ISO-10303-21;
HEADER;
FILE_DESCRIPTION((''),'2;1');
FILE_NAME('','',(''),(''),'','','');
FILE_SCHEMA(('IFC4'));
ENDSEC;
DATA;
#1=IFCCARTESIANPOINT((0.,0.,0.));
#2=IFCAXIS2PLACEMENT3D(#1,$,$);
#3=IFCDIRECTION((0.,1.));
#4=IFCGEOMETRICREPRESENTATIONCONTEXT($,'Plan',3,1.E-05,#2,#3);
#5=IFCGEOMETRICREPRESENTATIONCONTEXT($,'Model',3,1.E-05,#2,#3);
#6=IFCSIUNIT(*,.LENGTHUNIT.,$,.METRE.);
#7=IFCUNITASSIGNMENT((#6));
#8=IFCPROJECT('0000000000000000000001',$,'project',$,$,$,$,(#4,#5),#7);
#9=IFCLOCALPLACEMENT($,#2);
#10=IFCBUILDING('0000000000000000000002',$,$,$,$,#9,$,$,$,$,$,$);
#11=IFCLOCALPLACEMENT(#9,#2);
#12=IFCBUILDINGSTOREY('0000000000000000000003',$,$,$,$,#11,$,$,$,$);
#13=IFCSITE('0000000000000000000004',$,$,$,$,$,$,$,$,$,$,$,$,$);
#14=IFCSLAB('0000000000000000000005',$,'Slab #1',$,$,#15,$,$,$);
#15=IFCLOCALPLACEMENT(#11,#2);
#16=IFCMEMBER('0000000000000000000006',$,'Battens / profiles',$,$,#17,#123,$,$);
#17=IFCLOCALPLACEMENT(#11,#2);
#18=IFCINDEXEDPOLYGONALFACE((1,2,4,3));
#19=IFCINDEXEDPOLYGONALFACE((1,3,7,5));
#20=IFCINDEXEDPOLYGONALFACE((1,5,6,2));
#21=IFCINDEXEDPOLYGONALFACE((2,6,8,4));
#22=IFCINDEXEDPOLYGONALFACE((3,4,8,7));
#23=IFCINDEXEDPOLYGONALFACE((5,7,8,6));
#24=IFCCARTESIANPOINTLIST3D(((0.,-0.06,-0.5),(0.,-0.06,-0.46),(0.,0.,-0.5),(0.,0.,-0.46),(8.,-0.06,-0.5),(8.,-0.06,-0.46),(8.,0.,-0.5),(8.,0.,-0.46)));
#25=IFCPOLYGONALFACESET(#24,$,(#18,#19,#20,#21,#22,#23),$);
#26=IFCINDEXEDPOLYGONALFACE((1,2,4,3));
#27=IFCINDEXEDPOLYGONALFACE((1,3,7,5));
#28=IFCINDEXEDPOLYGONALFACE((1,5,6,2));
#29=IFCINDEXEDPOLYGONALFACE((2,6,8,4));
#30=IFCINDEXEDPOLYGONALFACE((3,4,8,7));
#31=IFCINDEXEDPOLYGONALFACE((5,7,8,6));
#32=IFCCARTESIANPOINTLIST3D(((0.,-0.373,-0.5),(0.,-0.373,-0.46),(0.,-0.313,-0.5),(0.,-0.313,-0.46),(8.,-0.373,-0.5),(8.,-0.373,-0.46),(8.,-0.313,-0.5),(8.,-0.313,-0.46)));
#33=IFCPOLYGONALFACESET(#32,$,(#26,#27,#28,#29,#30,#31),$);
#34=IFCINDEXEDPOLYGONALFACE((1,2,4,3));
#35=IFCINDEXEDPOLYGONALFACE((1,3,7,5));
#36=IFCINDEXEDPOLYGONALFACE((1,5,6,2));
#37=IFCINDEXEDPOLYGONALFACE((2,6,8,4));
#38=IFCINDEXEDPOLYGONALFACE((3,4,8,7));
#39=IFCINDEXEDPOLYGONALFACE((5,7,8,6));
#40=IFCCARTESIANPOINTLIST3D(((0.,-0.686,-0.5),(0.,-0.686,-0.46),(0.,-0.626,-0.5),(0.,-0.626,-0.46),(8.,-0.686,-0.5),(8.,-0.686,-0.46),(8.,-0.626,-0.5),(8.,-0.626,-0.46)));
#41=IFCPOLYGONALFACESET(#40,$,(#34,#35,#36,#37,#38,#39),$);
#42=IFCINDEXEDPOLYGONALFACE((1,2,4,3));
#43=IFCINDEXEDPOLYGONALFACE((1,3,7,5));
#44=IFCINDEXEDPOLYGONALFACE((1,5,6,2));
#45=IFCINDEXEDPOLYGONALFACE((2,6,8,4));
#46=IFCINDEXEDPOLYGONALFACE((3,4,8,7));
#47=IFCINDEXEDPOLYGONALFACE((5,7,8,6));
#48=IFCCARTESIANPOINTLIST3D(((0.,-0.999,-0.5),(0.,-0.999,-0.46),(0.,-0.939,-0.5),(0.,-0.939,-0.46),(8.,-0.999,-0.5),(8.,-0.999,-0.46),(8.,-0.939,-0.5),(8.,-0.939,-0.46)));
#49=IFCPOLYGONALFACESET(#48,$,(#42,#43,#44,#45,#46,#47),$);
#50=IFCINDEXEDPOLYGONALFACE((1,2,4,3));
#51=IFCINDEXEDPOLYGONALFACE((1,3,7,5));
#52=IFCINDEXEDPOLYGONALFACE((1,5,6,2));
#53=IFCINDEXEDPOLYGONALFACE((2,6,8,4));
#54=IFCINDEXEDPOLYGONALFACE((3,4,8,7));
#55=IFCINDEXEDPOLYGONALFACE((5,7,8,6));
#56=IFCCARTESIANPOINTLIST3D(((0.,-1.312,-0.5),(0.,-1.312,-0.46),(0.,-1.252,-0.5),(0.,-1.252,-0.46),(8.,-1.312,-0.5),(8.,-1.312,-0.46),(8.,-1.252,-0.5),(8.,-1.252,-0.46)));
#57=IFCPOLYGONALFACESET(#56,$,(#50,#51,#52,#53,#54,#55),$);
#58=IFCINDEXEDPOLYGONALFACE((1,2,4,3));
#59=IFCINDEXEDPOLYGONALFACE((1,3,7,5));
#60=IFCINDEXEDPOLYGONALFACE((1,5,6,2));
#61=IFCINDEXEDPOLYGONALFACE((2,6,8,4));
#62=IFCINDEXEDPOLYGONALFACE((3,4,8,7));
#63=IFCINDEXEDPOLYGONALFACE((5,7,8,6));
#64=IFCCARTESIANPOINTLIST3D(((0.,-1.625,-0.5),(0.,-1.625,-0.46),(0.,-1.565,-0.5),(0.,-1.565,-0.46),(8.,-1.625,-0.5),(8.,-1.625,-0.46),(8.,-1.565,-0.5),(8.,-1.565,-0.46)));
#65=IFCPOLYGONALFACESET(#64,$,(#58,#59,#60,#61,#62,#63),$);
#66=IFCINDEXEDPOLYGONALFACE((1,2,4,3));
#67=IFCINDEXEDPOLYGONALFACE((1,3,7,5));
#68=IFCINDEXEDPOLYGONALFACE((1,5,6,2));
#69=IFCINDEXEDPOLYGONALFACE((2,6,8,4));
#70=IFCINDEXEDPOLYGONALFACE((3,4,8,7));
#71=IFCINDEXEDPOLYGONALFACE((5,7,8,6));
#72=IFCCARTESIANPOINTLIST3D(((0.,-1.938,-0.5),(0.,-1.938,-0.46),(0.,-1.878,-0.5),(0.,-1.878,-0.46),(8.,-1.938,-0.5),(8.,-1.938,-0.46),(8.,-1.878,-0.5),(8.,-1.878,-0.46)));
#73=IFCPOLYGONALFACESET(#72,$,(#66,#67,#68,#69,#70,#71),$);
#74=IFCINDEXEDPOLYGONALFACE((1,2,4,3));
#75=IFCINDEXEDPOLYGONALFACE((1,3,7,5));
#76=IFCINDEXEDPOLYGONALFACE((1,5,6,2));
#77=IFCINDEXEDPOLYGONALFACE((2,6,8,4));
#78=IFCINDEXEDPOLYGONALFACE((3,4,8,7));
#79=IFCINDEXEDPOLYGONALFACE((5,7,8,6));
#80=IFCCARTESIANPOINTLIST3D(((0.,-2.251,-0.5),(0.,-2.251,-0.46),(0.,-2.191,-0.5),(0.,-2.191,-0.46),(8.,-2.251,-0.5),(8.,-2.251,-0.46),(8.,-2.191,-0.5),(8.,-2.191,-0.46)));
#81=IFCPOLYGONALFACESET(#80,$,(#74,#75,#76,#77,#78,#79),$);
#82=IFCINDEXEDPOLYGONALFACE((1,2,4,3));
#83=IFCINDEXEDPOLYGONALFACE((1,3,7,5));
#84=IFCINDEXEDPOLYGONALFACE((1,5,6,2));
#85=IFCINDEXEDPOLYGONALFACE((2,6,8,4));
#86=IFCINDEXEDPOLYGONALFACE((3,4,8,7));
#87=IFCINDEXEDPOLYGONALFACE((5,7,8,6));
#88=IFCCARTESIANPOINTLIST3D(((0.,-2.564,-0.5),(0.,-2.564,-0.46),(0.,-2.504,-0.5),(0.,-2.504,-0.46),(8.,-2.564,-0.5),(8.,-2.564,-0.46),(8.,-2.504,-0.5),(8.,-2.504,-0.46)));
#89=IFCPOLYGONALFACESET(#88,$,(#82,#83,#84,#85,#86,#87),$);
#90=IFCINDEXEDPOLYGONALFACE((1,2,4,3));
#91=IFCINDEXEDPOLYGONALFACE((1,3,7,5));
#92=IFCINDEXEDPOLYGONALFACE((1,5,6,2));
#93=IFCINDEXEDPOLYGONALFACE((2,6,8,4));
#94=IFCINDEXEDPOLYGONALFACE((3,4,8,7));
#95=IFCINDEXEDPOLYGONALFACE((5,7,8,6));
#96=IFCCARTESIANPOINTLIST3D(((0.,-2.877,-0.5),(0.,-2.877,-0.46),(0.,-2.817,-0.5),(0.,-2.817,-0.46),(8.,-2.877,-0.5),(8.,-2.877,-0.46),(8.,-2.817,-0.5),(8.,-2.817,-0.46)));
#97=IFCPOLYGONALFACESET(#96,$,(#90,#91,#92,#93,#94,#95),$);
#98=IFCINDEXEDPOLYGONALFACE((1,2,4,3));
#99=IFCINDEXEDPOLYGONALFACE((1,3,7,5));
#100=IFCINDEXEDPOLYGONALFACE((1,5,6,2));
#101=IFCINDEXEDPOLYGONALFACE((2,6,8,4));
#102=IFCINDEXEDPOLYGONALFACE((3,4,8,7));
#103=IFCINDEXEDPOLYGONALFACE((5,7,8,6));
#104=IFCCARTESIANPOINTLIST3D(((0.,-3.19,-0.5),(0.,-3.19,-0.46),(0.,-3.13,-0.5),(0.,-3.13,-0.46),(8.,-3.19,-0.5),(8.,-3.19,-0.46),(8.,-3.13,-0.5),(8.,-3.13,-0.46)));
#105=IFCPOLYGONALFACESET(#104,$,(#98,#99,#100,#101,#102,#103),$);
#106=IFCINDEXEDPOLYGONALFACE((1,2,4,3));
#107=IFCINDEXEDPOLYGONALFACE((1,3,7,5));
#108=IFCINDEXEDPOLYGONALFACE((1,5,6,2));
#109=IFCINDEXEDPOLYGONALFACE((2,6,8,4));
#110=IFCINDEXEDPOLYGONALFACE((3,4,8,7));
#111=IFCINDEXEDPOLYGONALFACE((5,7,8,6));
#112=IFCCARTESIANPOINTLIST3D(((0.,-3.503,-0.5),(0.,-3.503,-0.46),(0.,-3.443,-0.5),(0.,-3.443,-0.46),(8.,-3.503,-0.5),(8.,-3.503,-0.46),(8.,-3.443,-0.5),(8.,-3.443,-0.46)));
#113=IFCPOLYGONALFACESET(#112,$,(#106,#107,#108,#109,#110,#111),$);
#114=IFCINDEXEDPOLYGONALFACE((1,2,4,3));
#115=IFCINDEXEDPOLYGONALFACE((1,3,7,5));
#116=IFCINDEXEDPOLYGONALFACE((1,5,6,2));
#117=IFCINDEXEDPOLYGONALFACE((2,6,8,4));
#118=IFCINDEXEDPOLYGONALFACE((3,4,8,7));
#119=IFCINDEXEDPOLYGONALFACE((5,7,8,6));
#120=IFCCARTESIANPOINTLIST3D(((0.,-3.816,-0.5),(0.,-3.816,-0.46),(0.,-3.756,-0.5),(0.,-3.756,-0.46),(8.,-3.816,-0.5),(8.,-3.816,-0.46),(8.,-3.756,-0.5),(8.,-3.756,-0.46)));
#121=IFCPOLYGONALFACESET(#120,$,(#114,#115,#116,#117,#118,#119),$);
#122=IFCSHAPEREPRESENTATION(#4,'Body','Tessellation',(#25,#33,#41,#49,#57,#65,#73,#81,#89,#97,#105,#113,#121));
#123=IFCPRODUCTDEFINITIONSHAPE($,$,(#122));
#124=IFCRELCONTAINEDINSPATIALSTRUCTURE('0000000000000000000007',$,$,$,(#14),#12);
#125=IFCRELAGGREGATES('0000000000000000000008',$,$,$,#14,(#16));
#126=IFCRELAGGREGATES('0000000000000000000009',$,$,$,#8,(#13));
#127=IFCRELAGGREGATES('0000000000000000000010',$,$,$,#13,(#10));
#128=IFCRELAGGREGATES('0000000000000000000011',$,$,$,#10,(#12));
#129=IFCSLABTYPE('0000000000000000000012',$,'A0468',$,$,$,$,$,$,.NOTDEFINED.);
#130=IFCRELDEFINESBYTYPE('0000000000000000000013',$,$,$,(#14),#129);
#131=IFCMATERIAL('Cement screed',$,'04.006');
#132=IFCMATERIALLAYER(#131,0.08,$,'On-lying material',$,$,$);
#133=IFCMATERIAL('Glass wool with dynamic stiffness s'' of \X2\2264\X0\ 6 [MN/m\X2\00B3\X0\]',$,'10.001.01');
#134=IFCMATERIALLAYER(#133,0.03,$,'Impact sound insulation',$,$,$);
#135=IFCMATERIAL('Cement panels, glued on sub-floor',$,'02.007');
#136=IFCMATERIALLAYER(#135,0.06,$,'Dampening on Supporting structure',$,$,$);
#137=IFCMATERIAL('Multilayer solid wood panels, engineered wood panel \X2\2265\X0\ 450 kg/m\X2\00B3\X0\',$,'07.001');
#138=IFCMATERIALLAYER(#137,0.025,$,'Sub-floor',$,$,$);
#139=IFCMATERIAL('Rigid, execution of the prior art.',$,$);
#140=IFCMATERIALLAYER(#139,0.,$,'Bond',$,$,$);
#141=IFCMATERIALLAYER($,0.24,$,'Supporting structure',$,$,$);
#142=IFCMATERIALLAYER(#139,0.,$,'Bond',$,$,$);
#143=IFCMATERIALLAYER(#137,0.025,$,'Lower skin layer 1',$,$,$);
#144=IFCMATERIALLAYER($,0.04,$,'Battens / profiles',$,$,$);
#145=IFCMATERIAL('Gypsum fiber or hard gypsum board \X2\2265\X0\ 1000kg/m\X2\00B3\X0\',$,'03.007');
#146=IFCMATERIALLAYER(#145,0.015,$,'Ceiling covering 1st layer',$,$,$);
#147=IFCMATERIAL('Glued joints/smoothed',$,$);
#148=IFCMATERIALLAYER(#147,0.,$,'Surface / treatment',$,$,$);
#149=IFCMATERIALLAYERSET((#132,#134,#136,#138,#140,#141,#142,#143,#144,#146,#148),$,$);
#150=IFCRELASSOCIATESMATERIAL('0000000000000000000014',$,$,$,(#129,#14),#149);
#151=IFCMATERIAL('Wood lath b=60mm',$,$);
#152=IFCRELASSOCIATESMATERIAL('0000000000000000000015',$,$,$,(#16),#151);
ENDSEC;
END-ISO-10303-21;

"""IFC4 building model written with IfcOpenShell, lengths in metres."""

from ifc_helpers import new_model, si_unit, direction, frame, frame_2d, origin, place, context, project, spatial, rectangle, extrude, material, layer, layer_set, type_object, element, aggregate, save


model = new_model("IFC4")

# Units and contexts
plan_context = context("Plan", 3, precision=1e-05, world=origin(), true_north=direction((0.0, 1.0)))
model_context = context("Model", 3, precision=1e-05, world=origin(), true_north=direction((0.0, 1.0)))
ifc_project = project(units=[si_unit("LENGTHUNIT", "METRE")], contexts=[plan_context, model_context])

# Site, building, storey
site = spatial("IfcSite", under=ifc_project)
building_placement = place(None, origin())
building = spatial("IfcBuilding", under=site, at=building_placement)
storey_placement = place(building_placement, origin())
storey = spatial("IfcBuildingStorey", under=building, at=storey_placement)

# Slab, member
ifc_material_1 = material(Name="Cement screed", Category="04.006")
ifc_layer_1 = layer(ifc_material_1, 0.08, Name="On-lying material")
ifc_material_2 = material(Name="Glass wool with dynamic stiffness s' of ≤ 6 [MN/m³]", Category="10.001.01")
ifc_layer_2 = layer(ifc_material_2, 0.03, Name="Impact sound insulation")
ifc_material_3 = material(Name="Cement panels, glued on sub-floor", Category="02.007")
ifc_layer_3 = layer(ifc_material_3, 0.06, Name="Dampening on Supporting structure")
ifc_material_4 = material(Name="Multilayer solid wood panels, engineered wood panel ≥ 450 kg/m³", Category="07.001")
ifc_layer_4 = layer(ifc_material_4, 0.025, Name="Sub-floor")
ifc_material_5 = material(Name="Rigid, execution of the prior art.")
ifc_layer_5 = layer(ifc_material_5, 0.0, Name="Bond")
ifc_layer_6 = layer(None, 0.24, Name="Supporting structure")
ifc_layer_7 = layer(ifc_material_5, 0.0, Name="Bond")
ifc_layer_8 = layer(ifc_material_4, 0.025, Name="Lower skin layer 1")
ifc_layer_9 = layer(None, 0.04, Name="Battens / profiles")
ifc_material_6 = material(Name="Gypsum fiber or hard gypsum board ≥ 1000kg/m³", Category="03.007")
ifc_layer_10 = layer(ifc_material_6, 0.015, Name="Ceiling covering 1st layer")
ifc_material_7 = material(Name="Glued joints/smoothed")
ifc_layer_11 = layer(ifc_material_7, 0.0, Name="Surface / treatment")
ifc_layer_set = layer_set([ifc_layer_1, ifc_layer_2, ifc_layer_3, ifc_layer_4, ifc_layer_5, ifc_layer_6, ifc_layer_7, ifc_layer_8, ifc_layer_9, ifc_layer_10, ifc_layer_11])
slab_type = type_object("IfcSlabType", Name="A0468", PredefinedType="NOTDEFINED", material=ifc_layer_set)
slab_placement = place(None, frame((0.0, 0.0, 0.0), z_axis=(0.0, 0.0, -1.0), x_axis=(1.0, 0.0, 0.0)))
slab = element("IfcSlab", 1, at=slab_placement, inside=storey, type_object=slab_type, material=ifc_layer_set, Name="Slab #1")
ifc_material_8 = material(Name="Wood lath b=60mm")
member_1_placement = place(slab_placement, origin())
member_1 = element("IfcMember", 2, at=member_1_placement, material=ifc_material_8, Name="Battens / profiles", context=plan_context, shape_type="SweptSolid", body=[
    extrude(rectangle(XDim=0.06, YDim=0.04, at=frame_2d((0.03, 0.02), x_axis=(1.0, 0.0))), frame((0.0, 0.0, 0.46), z_axis=(1.0, 0.0, 0.0), x_axis=(0.0, 1.0, 0.0)), (0.0, 0.0, 1.0), 8.0),
    extrude(rectangle(XDim=0.06, YDim=0.04, at=frame_2d((0.03, 0.02), x_axis=(1.0, 0.0))), frame((0.0, 0.313, 0.46), z_axis=(1.0, 0.0, 0.0), x_axis=(0.0, 1.0, 0.0)), (0.0, 0.0, 1.0), 8.0),
    extrude(rectangle(XDim=0.06, YDim=0.04, at=frame_2d((0.03, 0.02), x_axis=(1.0, 0.0))), frame((0.0, 0.626, 0.46), z_axis=(1.0, 0.0, 0.0), x_axis=(0.0, 1.0, 0.0)), (0.0, 0.0, 1.0), 8.0),
    extrude(rectangle(XDim=0.06, YDim=0.04, at=frame_2d((0.03, 0.02), x_axis=(1.0, 0.0))), frame((0.0, 0.939, 0.46), z_axis=(1.0, 0.0, 0.0), x_axis=(0.0, 1.0, 0.0)), (0.0, 0.0, 1.0), 8.0),
    extrude(rectangle(XDim=0.06, YDim=0.04, at=frame_2d((0.03, 0.02), x_axis=(1.0, 0.0))), frame((0.0, 1.252, 0.46), z_axis=(1.0, 0.0, 0.0), x_axis=(0.0, 1.0, 0.0)), (0.0, 0.0, 1.0), 8.0),
    extrude(rectangle(XDim=0.06, YDim=0.04, at=frame_2d((0.03, 0.02), x_axis=(1.0, 0.0))), frame((0.0, 1.565, 0.46), z_axis=(1.0, 0.0, 0.0), x_axis=(0.0, 1.0, 0.0)), (0.0, 0.0, 1.0), 8.0),
    extrude(rectangle(XDim=0.06, YDim=0.04, at=frame_2d((0.03, 0.02), x_axis=(1.0, 0.0))), frame((0.0, 1.878, 0.46), z_axis=(1.0, 0.0, 0.0), x_axis=(0.0, 1.0, 0.0)), (0.0, 0.0, 1.0), 8.0),
    extrude(rectangle(XDim=0.06, YDim=0.04, at=frame_2d((0.03, 0.02), x_axis=(1.0, 0.0))), frame((0.0, 2.191, 0.46), z_axis=(1.0, 0.0, 0.0), x_axis=(0.0, 1.0, 0.0)), (0.0, 0.0, 1.0), 8.0),
    extrude(rectangle(XDim=0.06, YDim=0.04, at=frame_2d((0.03, 0.02), x_axis=(1.0, 0.0))), frame((0.0, 2.504, 0.46), z_axis=(1.0, 0.0, 0.0), x_axis=(0.0, 1.0, 0.0)), (0.0, 0.0, 1.0), 8.0),
    extrude(rectangle(XDim=0.06, YDim=0.04, at=frame_2d((0.03, 0.02), x_axis=(1.0, 0.0))), frame((0.0, 2.817, 0.46), z_axis=(1.0, 0.0, 0.0), x_axis=(0.0, 1.0, 0.0)), (0.0, 0.0, 1.0), 8.0),
    extrude(rectangle(XDim=0.06, YDim=0.04, at=frame_2d((0.03, 0.02), x_axis=(1.0, 0.0))), frame((0.0, 3.13, 0.46), z_axis=(1.0, 0.0, 0.0), x_axis=(0.0, 1.0, 0.0)), (0.0, 0.0, 1.0), 8.0),
    extrude(rectangle(XDim=0.06, YDim=0.04, at=frame_2d((0.03, 0.02), x_axis=(1.0, 0.0))), frame((0.0, 3.443, 0.46), z_axis=(1.0, 0.0, 0.0), x_axis=(0.0, 1.0, 0.0)), (0.0, 0.0, 1.0), 8.0),
    extrude(rectangle(XDim=0.06, YDim=0.04, at=frame_2d((0.03, 0.02), x_axis=(1.0, 0.0))), frame((0.0, 3.756, 0.46), z_axis=(1.0, 0.0, 0.0), x_axis=(0.0, 1.0, 0.0)), (0.0, 0.0, 1.0), 8.0),
])
aggregate(slab, [member_1])

save(model, "model.ifc")
